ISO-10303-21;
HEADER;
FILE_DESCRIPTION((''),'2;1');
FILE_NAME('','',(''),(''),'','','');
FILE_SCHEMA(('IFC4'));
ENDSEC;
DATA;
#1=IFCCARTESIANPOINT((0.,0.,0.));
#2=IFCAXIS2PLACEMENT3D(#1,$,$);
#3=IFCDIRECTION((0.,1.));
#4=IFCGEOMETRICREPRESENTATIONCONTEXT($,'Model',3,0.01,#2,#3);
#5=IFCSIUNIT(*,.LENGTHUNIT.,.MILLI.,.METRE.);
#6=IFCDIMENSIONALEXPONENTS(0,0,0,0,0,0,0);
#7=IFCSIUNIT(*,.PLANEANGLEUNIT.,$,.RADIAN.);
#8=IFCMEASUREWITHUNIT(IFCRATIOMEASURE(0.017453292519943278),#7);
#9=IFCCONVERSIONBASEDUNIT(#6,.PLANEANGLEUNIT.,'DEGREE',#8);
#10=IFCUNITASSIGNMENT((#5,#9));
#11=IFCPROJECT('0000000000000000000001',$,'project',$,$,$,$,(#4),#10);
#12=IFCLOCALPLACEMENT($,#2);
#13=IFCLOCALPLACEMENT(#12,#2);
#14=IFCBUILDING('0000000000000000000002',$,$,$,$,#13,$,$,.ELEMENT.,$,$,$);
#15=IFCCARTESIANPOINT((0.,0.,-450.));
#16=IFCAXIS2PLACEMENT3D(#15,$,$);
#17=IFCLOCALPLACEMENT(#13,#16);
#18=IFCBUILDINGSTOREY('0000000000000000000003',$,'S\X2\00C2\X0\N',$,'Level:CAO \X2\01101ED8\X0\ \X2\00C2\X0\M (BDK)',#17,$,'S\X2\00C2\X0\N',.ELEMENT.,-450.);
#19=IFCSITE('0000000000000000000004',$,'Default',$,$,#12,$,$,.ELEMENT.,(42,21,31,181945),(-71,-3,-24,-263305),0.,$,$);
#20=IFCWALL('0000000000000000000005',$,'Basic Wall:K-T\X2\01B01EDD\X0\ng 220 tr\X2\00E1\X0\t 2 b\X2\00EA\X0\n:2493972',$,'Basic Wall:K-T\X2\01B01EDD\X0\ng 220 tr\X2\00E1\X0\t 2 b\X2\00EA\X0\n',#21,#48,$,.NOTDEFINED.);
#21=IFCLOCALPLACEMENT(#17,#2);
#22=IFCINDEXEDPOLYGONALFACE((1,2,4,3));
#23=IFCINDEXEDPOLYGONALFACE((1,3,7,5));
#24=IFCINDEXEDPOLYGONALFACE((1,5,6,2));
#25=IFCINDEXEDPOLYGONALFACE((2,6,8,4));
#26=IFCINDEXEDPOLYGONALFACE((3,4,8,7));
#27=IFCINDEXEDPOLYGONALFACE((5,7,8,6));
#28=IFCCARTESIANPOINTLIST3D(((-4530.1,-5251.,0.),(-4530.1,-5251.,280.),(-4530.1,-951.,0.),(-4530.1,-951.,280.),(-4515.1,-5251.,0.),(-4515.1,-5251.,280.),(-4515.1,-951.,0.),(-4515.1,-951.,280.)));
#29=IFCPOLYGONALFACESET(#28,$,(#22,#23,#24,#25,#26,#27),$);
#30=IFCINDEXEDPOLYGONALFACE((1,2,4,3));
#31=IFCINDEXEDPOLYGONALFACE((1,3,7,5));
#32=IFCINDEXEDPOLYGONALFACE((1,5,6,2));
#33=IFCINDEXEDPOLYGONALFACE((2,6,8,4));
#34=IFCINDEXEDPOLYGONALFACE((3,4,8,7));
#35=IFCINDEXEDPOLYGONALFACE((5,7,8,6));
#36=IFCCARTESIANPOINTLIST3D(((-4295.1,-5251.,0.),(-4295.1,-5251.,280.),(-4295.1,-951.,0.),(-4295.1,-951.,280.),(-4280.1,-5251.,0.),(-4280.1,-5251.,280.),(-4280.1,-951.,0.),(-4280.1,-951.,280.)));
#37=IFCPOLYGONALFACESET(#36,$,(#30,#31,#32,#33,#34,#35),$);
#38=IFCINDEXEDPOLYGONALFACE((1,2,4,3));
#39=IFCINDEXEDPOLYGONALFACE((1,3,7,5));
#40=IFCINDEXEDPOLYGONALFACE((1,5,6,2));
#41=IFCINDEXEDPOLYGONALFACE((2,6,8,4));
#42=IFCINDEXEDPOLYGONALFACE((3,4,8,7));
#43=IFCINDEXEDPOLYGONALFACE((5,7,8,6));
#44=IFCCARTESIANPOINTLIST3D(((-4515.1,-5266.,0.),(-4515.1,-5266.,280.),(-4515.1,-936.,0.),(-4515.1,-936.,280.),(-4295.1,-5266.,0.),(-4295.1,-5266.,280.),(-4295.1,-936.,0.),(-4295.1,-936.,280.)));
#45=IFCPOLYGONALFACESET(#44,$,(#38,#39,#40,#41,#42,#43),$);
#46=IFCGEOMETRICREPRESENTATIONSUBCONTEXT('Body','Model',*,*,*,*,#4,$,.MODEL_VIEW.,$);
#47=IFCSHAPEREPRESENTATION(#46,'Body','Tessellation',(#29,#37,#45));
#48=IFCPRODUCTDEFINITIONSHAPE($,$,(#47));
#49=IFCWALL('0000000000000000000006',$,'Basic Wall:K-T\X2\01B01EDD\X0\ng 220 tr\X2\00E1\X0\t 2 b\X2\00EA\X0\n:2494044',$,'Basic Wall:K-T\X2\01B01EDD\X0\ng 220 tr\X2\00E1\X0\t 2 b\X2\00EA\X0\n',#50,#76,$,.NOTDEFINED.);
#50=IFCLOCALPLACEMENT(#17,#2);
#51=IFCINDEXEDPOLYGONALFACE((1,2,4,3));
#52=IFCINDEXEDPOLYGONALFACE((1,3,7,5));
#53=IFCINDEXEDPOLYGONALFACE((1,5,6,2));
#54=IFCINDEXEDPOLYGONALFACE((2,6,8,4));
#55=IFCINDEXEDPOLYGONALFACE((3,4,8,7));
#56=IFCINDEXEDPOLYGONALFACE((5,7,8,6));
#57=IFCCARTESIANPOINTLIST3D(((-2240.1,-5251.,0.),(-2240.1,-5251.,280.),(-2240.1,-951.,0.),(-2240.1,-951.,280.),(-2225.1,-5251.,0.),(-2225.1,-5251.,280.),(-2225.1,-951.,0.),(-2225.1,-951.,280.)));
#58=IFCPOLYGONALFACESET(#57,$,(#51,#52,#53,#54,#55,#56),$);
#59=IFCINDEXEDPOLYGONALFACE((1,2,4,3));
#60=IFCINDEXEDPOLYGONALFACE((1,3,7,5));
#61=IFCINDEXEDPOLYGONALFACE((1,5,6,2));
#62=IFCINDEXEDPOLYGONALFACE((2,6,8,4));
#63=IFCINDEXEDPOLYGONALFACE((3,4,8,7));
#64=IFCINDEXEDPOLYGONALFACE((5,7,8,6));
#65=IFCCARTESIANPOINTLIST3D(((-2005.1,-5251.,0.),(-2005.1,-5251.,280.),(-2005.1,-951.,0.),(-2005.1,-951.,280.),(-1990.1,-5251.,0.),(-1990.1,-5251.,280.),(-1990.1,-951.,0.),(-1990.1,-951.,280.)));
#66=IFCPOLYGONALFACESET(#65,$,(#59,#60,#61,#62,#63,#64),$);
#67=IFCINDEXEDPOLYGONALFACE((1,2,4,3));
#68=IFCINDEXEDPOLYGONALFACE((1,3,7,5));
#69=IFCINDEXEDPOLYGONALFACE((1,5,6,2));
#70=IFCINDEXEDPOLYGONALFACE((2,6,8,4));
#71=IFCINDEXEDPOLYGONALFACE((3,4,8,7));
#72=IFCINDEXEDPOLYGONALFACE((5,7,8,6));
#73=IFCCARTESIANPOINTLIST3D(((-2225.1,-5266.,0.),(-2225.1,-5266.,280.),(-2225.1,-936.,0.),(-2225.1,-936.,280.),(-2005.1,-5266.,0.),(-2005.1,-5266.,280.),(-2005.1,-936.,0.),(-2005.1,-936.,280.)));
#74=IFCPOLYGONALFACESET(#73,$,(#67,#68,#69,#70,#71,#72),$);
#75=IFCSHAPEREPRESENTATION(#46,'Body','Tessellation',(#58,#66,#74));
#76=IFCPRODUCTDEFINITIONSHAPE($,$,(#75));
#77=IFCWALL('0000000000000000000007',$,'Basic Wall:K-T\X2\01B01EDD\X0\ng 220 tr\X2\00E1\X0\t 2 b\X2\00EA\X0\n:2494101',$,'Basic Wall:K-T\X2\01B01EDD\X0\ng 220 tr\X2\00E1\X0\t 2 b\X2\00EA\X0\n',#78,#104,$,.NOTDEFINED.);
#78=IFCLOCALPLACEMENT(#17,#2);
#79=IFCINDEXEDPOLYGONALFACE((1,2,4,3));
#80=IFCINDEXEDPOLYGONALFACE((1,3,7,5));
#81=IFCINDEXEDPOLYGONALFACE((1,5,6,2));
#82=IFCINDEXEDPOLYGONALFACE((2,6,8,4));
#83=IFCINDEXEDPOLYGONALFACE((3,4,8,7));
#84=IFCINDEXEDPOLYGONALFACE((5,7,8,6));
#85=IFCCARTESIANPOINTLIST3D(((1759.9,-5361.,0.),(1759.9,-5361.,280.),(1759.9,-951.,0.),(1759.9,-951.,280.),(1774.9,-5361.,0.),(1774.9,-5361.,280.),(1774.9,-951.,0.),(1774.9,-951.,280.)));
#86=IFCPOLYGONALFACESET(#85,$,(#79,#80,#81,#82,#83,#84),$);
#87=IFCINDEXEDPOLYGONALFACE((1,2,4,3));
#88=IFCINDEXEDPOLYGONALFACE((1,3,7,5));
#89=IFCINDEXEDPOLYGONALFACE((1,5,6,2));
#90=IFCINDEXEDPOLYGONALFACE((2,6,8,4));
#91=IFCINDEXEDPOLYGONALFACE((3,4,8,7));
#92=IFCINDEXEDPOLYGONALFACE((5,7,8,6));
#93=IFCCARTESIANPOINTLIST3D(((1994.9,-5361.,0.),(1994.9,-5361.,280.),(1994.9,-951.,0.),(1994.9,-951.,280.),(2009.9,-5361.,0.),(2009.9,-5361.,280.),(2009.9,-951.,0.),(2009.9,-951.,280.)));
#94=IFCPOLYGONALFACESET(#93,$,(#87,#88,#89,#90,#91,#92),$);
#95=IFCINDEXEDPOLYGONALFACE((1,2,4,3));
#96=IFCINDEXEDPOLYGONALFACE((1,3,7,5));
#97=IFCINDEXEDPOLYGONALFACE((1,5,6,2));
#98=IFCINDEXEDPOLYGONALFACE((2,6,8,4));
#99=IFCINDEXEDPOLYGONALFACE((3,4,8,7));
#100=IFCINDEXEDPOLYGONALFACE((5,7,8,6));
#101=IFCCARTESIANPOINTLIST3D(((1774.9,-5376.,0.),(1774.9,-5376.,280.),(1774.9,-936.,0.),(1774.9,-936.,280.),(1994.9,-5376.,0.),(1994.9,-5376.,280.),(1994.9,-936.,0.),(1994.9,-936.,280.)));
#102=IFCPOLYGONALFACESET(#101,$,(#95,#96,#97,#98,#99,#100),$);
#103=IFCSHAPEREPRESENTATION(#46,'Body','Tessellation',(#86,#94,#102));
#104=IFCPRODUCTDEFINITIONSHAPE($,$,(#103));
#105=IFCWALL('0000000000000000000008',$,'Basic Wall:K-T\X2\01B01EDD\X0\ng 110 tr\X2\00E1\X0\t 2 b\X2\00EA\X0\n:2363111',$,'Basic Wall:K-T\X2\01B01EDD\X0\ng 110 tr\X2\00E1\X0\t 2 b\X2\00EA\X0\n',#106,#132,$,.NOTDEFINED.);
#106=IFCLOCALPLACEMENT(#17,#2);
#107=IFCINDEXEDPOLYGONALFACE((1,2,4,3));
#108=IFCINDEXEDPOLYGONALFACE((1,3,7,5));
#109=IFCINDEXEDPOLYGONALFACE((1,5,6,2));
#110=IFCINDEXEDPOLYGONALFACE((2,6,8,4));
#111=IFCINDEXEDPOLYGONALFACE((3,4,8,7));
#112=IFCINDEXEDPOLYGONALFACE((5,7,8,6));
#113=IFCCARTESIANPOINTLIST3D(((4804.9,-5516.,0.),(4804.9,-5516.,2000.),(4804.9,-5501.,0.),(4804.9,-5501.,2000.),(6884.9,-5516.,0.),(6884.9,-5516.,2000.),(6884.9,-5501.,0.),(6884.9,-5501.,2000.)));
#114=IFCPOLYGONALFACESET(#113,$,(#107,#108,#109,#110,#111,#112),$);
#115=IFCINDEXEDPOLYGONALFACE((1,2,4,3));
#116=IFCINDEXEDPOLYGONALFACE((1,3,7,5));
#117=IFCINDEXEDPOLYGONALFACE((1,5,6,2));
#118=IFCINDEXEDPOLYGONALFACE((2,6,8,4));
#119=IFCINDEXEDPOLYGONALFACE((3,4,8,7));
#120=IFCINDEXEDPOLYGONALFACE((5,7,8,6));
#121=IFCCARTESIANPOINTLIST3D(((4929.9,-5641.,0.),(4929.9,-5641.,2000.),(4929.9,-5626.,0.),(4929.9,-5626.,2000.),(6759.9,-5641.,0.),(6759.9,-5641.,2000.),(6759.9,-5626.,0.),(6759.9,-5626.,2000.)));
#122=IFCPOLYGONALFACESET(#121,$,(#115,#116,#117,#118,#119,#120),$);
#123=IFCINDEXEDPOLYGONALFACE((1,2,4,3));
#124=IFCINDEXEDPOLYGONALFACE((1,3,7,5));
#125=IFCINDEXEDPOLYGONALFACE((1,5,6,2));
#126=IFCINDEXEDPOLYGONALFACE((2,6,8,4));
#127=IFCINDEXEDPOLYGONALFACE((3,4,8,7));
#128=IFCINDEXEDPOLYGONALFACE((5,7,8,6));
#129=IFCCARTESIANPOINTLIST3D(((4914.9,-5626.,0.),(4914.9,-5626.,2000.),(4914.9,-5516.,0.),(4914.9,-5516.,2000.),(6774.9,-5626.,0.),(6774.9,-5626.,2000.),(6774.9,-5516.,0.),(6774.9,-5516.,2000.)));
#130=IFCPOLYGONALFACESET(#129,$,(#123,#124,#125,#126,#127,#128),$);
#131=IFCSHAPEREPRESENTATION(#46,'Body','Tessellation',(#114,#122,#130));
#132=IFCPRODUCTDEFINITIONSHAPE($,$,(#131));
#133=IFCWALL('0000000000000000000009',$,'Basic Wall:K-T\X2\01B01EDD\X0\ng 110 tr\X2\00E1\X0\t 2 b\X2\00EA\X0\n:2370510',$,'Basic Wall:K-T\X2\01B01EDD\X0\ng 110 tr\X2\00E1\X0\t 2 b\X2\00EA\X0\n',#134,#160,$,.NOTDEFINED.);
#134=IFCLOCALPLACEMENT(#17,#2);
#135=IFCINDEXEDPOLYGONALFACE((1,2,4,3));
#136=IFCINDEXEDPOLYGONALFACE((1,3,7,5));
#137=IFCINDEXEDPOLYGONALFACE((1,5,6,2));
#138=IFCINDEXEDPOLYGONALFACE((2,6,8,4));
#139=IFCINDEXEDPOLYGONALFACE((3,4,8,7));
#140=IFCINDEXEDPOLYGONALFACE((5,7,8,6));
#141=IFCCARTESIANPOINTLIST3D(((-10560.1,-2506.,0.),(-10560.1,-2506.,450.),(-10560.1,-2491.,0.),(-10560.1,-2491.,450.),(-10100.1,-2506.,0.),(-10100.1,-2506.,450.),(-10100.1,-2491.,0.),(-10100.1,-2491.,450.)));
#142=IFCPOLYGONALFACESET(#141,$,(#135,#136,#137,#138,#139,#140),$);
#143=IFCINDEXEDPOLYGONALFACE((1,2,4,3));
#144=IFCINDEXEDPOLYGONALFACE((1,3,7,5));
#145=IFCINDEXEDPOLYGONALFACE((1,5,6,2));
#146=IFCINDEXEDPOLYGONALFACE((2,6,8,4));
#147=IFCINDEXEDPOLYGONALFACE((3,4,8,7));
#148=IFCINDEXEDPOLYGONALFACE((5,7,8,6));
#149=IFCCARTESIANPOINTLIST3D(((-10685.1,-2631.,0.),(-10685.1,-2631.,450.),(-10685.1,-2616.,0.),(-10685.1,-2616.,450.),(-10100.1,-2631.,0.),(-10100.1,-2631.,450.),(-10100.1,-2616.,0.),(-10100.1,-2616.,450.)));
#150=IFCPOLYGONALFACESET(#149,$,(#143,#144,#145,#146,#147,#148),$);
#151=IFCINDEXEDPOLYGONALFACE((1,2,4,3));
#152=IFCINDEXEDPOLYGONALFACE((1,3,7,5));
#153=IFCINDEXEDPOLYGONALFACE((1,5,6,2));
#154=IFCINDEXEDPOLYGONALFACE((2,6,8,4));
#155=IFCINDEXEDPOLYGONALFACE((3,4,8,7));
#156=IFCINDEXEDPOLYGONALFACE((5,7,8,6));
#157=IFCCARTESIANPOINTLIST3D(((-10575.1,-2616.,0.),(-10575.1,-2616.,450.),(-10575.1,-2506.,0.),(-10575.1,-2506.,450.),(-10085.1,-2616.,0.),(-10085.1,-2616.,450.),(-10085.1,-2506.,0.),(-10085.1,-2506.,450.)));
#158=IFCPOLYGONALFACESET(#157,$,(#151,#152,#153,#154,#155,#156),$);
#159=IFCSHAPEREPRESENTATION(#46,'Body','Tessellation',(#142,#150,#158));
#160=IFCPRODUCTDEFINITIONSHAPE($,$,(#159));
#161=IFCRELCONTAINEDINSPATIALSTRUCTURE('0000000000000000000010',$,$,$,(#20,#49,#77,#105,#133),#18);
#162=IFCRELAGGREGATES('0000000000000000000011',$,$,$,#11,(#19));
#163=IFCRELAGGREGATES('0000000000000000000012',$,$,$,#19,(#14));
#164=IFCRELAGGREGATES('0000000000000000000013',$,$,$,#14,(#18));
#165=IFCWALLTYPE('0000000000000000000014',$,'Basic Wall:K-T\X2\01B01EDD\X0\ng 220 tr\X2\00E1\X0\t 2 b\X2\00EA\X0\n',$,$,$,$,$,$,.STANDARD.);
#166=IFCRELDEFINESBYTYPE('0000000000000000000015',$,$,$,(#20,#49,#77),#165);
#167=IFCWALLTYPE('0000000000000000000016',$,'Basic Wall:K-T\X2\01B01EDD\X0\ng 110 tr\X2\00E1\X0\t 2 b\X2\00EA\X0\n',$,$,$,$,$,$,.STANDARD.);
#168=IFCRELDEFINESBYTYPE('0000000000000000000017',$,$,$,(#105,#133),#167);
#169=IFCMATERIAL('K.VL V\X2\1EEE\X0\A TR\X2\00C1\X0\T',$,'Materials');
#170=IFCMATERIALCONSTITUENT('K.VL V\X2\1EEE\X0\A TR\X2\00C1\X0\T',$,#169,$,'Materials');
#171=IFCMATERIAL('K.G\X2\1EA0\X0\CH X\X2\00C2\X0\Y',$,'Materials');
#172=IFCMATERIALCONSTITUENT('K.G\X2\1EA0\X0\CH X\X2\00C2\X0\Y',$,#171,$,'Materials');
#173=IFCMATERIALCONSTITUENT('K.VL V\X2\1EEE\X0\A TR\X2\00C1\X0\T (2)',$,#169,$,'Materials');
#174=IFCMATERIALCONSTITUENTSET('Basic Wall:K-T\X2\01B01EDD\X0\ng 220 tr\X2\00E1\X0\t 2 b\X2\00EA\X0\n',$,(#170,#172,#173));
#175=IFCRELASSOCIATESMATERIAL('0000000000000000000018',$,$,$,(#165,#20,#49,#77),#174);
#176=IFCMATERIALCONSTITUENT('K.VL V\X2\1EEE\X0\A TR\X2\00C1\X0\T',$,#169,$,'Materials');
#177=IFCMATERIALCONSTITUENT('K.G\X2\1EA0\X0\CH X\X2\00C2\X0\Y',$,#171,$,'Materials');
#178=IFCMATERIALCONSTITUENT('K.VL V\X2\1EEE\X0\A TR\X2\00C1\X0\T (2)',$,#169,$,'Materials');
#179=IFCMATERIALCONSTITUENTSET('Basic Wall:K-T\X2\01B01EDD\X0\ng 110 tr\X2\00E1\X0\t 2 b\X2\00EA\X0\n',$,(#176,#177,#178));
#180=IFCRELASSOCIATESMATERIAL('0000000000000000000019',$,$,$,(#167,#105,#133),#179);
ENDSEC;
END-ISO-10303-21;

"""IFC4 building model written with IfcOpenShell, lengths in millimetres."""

from ifc_helpers import new_model, entity, si_unit, converted_unit, direction, frame, origin, place, context, subcontext, project, spatial, indexed_curve, outline, extrude, material, constituent, constituent_set, type_object, element, save


model = new_model("IFC4")

# Units and contexts
model_context = context("Model", 3, precision=0.01, world=origin(), true_north=direction((0.0, 1.0)))
body_context = subcontext(model_context, "Body", "Model", "MODEL_VIEW")
ifc_project = project(units=[si_unit("LENGTHUNIT", "METRE", prefix="MILLI"), converted_unit("PLANEANGLEUNIT", "DEGREE", entity("IfcRatioMeasure", 0.017453292519943278), si_unit("PLANEANGLEUNIT", "RADIAN"), dimensions=[0, 0, 0, 0, 0, 0, 0])], contexts=[model_context])

# Site, building, storey
site_placement = place(None, origin())
site = spatial("IfcSite", under=ifc_project, at=site_placement, Name="Default", CompositionType="ELEMENT", RefLatitude=(42, 21, 31, 181945), RefLongitude=(-71, -3, -24, -263305), RefElevation=0.0)
building_placement = place(site_placement, origin())
building = spatial("IfcBuilding", under=site, at=building_placement, CompositionType="ELEMENT")
storey_placement = place(building_placement, frame((0.0, 0.0, -450.0)))
storey = spatial("IfcBuildingStorey", under=building, at=storey_placement, Name="SÂN", ObjectType="Level:CAO ĐỘ ÂM (BDK)", LongName="SÂN", CompositionType="ELEMENT", Elevation=-450.0)

# Shared definitions
ifc_material_1 = material(Name="K.VL VỮA TRÁT", Category="Materials")
ifc_constituent_1 = constituent(ifc_material_1, Name="K.VL VỮA TRÁT", Category="Materials")
ifc_material_2 = material(Name="K.GẠCH XÂY", Category="Materials")
ifc_constituent_2 = constituent(ifc_material_2, Name="K.GẠCH XÂY", Category="Materials")
ifc_constituent_3 = constituent(ifc_material_1, Name="K.VL VỮA TRÁT (2)", Category="Materials")
ifc_constituent_set_1 = constituent_set(constituents=[ifc_constituent_1, ifc_constituent_2, ifc_constituent_3], Name="Basic Wall:K-Tường 220 trát 2 bên")
wall_type_1 = type_object("IfcWallType", Name="Basic Wall:K-Tường 220 trát 2 bên", PredefinedType="STANDARD", material=ifc_constituent_set_1)

# Walls
wall_1_placement = place(storey_placement, frame((-4405.1, -951.0, 0.0), z_axis=(0.0, 0.0, 1.0), x_axis=(0.0, -1.0, 0.0)))
element("IfcWall", 1, at=wall_1_placement, inside=storey, type_object=wall_type_1, material=ifc_constituent_set_1, Name="Basic Wall:K-Tường 220 trát 2 bên:2493972", ObjectType="Basic Wall:K-Tường 220 trát 2 bên", PredefinedType="NOTDEFINED", context=body_context, shape_type="SweptSolid", body=[
    extrude(outline(indexed_curve([(-7.5, -2150.0), (7.5, -2150.0), (7.5, 2150.0), (-7.5, 2150.0), (-7.5, -2150.0)], self_intersect=False)), frame((2150.0, -117.5, 0.0), z_axis=(0.0, 0.0, 1.0), x_axis=(0.0, 1.0, 0.0)), (0.0, 0.0, 1.0), 280.0),
    extrude(outline(indexed_curve([(-7.5, -2150.0), (7.5, -2150.0), (7.5, 2150.0), (-7.5, 2150.0), (-7.5, -2150.0)], self_intersect=False)), frame((2150.0, 117.5, 0.0), z_axis=(0.0, 0.0, 1.0), x_axis=(0.0, -1.0, 0.0)), (0.0, 0.0, 1.0), 280.0),
    extrude(outline(indexed_curve([(-2165.0, -110.0), (2165.0, -110.0), (2165.0, 110.0), (-2165.0, 110.0), (-2165.0, -110.0)], self_intersect=False)), frame((2150.0, 0.0, 0.0)), (0.0, 0.0, 1.0), 280.0),
])
wall_2_placement = place(storey_placement, frame((-2115.1, -951.0, 0.0), z_axis=(0.0, 0.0, 1.0), x_axis=(0.0, -1.0, 0.0)))
element("IfcWall", 2, at=wall_2_placement, inside=storey, type_object=wall_type_1, material=ifc_constituent_set_1, Name="Basic Wall:K-Tường 220 trát 2 bên:2494044", ObjectType="Basic Wall:K-Tường 220 trát 2 bên", PredefinedType="NOTDEFINED", context=body_context, shape_type="SweptSolid", body=[
    extrude(outline(indexed_curve([(-7.5, -2150.0), (7.5, -2150.0), (7.5, 2150.0), (-7.5, 2150.0), (-7.5, -2150.0)], self_intersect=False)), frame((2150.0, -117.5, 0.0), z_axis=(0.0, 0.0, 1.0), x_axis=(0.0, 1.0, 0.0)), (0.0, 0.0, 1.0), 280.0),
    extrude(outline(indexed_curve([(-7.5, -2150.0), (7.5, -2150.0), (7.5, 2150.0), (-7.5, 2150.0), (-7.5, -2150.0)], self_intersect=False)), frame((2150.0, 117.5, 0.0), z_axis=(0.0, 0.0, 1.0), x_axis=(0.0, -1.0, 0.0)), (0.0, 0.0, 1.0), 280.0),
    extrude(outline(indexed_curve([(-2165.0, -110.0), (2165.0, -110.0), (2165.0, 110.0), (-2165.0, 110.0), (-2165.0, -110.0)], self_intersect=False)), frame((2150.0, 0.0, 0.0)), (0.0, 0.0, 1.0), 280.0),
])
wall_3_placement = place(storey_placement, frame((1884.9, -951.0, 0.0), z_axis=(0.0, 0.0, 1.0), x_axis=(0.0, -1.0, 0.0)))
element("IfcWall", 3, at=wall_3_placement, inside=storey, type_object=wall_type_1, material=ifc_constituent_set_1, Name="Basic Wall:K-Tường 220 trát 2 bên:2494101", ObjectType="Basic Wall:K-Tường 220 trát 2 bên", PredefinedType="NOTDEFINED", context=body_context, shape_type="SweptSolid", body=[
    extrude(outline(indexed_curve([(-7.5, -2205.0), (7.5, -2205.0), (7.5, 2205.0), (-7.5, 2205.0), (-7.5, -2205.0)], self_intersect=False)), frame((2205.0, -117.5, 0.0), z_axis=(0.0, 0.0, 1.0), x_axis=(0.0, 1.0, 0.0)), (0.0, 0.0, 1.0), 280.0),
    extrude(outline(indexed_curve([(-7.5, -2205.0), (7.5, -2205.0), (7.5, 2205.0), (-7.5, 2205.0), (-7.5, -2205.0)], self_intersect=False)), frame((2205.0, 117.5, 0.0), z_axis=(0.0, 0.0, 1.0), x_axis=(0.0, -1.0, 0.0)), (0.0, 0.0, 1.0), 280.0),
    extrude(outline(indexed_curve([(-2220.0, -110.0), (2220.0, -110.0), (2220.0, 110.0), (-2220.0, 110.0), (-2220.0, -110.0)], self_intersect=False)), frame((2205.0, 0.0, 0.0), z_axis=(0.0, 0.0, 1.0), x_axis=(-1.0, 0.0, 0.0)), (0.0, 0.0, 1.0), 280.0),
])
ifc_constituent_4 = constituent(ifc_material_1, Name="K.VL VỮA TRÁT", Category="Materials")
ifc_constituent_5 = constituent(ifc_material_2, Name="K.GẠCH XÂY", Category="Materials")
ifc_constituent_6 = constituent(ifc_material_1, Name="K.VL VỮA TRÁT (2)", Category="Materials")
ifc_constituent_set_2 = constituent_set(constituents=[ifc_constituent_4, ifc_constituent_5, ifc_constituent_6], Name="Basic Wall:K-Tường 110 trát 2 bên")
wall_type_2 = type_object("IfcWallType", Name="Basic Wall:K-Tường 110 trát 2 bên", PredefinedType="STANDARD", material=ifc_constituent_set_2)

# Walls
wall_4_placement = place(storey_placement, frame((6759.9, -5571.0, 0.0), z_axis=(0.0, 0.0, 1.0), x_axis=(-1.0, 0.0, 0.0)))
element("IfcWall", 4, at=wall_4_placement, inside=storey, type_object=wall_type_2, material=ifc_constituent_set_2, Name="Basic Wall:K-Tường 110 trát 2 bên:2363111", ObjectType="Basic Wall:K-Tường 110 trát 2 bên", PredefinedType="NOTDEFINED", context=body_context, shape_type="SweptSolid", body=[
    extrude(outline(indexed_curve([(-7.5, -1040.0), (7.5, -1040.0), (7.5, 1040.0), (-7.5, 1040.0), (-7.5, -1040.0)], self_intersect=False)), frame((915.0, -62.5, 0.0), z_axis=(0.0, 0.0, 1.0), x_axis=(0.0, 1.0, 0.0)), (0.0, 0.0, 1.0), 2000.0),
    extrude(outline(indexed_curve([(-7.5, -915.0), (7.5, -915.0), (7.5, 915.0), (-7.5, 915.0), (-7.5, -915.0)], self_intersect=False)), frame((915.0, 62.5, 0.0), z_axis=(0.0, 0.0, 1.0), x_axis=(0.0, -1.0, 0.0)), (0.0, 0.0, 1.0), 2000.0),
    extrude(outline(indexed_curve([(-930.0, -55.0), (930.0, -55.0), (930.0, 55.0), (-930.0, 55.0), (-930.0, -55.0)], self_intersect=False)), frame((915.0, 0.0, 0.0)), (0.0, 0.0, 1.0), 2000.0),
])
wall_5_placement = place(storey_placement, frame((-10560.1, -2561.0, 0.0)))
element("IfcWall", 5, at=wall_5_placement, inside=storey, type_object=wall_type_2, material=ifc_constituent_set_2, Name="Basic Wall:K-Tường 110 trát 2 bên:2370510", ObjectType="Basic Wall:K-Tường 110 trát 2 bên", PredefinedType="NOTDEFINED", context=body_context, shape_type="SweptSolid", body=[
    extrude(outline(indexed_curve([(-7.5, -230.0), (7.5, -230.0), (7.5, 230.0), (-7.5, 230.0), (-7.5, -230.0)], self_intersect=False)), frame((230.0, 62.5, 0.0), z_axis=(0.0, 0.0, 1.0), x_axis=(0.0, -1.0, 0.0)), (0.0, 0.0, 1.0), 450.0),
    extrude(outline(indexed_curve([(-7.5, -292.5), (7.5, -292.5), (7.5, 292.5), (-7.5, 292.5), (-7.5, -292.5)], self_intersect=False)), frame((167.5, -62.5, 0.0), z_axis=(0.0, 0.0, 1.0), x_axis=(0.0, 1.0, 0.0)), (0.0, 0.0, 1.0), 450.0),
    extrude(outline(indexed_curve([(-245.0, -55.0), (245.0, -55.0), (245.0, 55.0), (-245.0, 55.0), (-245.0, -55.0)], self_intersect=False)), frame((230.0, 0.0, 0.0)), (0.0, 0.0, 1.0), 450.0),
])

save(model, "model.ifc")
